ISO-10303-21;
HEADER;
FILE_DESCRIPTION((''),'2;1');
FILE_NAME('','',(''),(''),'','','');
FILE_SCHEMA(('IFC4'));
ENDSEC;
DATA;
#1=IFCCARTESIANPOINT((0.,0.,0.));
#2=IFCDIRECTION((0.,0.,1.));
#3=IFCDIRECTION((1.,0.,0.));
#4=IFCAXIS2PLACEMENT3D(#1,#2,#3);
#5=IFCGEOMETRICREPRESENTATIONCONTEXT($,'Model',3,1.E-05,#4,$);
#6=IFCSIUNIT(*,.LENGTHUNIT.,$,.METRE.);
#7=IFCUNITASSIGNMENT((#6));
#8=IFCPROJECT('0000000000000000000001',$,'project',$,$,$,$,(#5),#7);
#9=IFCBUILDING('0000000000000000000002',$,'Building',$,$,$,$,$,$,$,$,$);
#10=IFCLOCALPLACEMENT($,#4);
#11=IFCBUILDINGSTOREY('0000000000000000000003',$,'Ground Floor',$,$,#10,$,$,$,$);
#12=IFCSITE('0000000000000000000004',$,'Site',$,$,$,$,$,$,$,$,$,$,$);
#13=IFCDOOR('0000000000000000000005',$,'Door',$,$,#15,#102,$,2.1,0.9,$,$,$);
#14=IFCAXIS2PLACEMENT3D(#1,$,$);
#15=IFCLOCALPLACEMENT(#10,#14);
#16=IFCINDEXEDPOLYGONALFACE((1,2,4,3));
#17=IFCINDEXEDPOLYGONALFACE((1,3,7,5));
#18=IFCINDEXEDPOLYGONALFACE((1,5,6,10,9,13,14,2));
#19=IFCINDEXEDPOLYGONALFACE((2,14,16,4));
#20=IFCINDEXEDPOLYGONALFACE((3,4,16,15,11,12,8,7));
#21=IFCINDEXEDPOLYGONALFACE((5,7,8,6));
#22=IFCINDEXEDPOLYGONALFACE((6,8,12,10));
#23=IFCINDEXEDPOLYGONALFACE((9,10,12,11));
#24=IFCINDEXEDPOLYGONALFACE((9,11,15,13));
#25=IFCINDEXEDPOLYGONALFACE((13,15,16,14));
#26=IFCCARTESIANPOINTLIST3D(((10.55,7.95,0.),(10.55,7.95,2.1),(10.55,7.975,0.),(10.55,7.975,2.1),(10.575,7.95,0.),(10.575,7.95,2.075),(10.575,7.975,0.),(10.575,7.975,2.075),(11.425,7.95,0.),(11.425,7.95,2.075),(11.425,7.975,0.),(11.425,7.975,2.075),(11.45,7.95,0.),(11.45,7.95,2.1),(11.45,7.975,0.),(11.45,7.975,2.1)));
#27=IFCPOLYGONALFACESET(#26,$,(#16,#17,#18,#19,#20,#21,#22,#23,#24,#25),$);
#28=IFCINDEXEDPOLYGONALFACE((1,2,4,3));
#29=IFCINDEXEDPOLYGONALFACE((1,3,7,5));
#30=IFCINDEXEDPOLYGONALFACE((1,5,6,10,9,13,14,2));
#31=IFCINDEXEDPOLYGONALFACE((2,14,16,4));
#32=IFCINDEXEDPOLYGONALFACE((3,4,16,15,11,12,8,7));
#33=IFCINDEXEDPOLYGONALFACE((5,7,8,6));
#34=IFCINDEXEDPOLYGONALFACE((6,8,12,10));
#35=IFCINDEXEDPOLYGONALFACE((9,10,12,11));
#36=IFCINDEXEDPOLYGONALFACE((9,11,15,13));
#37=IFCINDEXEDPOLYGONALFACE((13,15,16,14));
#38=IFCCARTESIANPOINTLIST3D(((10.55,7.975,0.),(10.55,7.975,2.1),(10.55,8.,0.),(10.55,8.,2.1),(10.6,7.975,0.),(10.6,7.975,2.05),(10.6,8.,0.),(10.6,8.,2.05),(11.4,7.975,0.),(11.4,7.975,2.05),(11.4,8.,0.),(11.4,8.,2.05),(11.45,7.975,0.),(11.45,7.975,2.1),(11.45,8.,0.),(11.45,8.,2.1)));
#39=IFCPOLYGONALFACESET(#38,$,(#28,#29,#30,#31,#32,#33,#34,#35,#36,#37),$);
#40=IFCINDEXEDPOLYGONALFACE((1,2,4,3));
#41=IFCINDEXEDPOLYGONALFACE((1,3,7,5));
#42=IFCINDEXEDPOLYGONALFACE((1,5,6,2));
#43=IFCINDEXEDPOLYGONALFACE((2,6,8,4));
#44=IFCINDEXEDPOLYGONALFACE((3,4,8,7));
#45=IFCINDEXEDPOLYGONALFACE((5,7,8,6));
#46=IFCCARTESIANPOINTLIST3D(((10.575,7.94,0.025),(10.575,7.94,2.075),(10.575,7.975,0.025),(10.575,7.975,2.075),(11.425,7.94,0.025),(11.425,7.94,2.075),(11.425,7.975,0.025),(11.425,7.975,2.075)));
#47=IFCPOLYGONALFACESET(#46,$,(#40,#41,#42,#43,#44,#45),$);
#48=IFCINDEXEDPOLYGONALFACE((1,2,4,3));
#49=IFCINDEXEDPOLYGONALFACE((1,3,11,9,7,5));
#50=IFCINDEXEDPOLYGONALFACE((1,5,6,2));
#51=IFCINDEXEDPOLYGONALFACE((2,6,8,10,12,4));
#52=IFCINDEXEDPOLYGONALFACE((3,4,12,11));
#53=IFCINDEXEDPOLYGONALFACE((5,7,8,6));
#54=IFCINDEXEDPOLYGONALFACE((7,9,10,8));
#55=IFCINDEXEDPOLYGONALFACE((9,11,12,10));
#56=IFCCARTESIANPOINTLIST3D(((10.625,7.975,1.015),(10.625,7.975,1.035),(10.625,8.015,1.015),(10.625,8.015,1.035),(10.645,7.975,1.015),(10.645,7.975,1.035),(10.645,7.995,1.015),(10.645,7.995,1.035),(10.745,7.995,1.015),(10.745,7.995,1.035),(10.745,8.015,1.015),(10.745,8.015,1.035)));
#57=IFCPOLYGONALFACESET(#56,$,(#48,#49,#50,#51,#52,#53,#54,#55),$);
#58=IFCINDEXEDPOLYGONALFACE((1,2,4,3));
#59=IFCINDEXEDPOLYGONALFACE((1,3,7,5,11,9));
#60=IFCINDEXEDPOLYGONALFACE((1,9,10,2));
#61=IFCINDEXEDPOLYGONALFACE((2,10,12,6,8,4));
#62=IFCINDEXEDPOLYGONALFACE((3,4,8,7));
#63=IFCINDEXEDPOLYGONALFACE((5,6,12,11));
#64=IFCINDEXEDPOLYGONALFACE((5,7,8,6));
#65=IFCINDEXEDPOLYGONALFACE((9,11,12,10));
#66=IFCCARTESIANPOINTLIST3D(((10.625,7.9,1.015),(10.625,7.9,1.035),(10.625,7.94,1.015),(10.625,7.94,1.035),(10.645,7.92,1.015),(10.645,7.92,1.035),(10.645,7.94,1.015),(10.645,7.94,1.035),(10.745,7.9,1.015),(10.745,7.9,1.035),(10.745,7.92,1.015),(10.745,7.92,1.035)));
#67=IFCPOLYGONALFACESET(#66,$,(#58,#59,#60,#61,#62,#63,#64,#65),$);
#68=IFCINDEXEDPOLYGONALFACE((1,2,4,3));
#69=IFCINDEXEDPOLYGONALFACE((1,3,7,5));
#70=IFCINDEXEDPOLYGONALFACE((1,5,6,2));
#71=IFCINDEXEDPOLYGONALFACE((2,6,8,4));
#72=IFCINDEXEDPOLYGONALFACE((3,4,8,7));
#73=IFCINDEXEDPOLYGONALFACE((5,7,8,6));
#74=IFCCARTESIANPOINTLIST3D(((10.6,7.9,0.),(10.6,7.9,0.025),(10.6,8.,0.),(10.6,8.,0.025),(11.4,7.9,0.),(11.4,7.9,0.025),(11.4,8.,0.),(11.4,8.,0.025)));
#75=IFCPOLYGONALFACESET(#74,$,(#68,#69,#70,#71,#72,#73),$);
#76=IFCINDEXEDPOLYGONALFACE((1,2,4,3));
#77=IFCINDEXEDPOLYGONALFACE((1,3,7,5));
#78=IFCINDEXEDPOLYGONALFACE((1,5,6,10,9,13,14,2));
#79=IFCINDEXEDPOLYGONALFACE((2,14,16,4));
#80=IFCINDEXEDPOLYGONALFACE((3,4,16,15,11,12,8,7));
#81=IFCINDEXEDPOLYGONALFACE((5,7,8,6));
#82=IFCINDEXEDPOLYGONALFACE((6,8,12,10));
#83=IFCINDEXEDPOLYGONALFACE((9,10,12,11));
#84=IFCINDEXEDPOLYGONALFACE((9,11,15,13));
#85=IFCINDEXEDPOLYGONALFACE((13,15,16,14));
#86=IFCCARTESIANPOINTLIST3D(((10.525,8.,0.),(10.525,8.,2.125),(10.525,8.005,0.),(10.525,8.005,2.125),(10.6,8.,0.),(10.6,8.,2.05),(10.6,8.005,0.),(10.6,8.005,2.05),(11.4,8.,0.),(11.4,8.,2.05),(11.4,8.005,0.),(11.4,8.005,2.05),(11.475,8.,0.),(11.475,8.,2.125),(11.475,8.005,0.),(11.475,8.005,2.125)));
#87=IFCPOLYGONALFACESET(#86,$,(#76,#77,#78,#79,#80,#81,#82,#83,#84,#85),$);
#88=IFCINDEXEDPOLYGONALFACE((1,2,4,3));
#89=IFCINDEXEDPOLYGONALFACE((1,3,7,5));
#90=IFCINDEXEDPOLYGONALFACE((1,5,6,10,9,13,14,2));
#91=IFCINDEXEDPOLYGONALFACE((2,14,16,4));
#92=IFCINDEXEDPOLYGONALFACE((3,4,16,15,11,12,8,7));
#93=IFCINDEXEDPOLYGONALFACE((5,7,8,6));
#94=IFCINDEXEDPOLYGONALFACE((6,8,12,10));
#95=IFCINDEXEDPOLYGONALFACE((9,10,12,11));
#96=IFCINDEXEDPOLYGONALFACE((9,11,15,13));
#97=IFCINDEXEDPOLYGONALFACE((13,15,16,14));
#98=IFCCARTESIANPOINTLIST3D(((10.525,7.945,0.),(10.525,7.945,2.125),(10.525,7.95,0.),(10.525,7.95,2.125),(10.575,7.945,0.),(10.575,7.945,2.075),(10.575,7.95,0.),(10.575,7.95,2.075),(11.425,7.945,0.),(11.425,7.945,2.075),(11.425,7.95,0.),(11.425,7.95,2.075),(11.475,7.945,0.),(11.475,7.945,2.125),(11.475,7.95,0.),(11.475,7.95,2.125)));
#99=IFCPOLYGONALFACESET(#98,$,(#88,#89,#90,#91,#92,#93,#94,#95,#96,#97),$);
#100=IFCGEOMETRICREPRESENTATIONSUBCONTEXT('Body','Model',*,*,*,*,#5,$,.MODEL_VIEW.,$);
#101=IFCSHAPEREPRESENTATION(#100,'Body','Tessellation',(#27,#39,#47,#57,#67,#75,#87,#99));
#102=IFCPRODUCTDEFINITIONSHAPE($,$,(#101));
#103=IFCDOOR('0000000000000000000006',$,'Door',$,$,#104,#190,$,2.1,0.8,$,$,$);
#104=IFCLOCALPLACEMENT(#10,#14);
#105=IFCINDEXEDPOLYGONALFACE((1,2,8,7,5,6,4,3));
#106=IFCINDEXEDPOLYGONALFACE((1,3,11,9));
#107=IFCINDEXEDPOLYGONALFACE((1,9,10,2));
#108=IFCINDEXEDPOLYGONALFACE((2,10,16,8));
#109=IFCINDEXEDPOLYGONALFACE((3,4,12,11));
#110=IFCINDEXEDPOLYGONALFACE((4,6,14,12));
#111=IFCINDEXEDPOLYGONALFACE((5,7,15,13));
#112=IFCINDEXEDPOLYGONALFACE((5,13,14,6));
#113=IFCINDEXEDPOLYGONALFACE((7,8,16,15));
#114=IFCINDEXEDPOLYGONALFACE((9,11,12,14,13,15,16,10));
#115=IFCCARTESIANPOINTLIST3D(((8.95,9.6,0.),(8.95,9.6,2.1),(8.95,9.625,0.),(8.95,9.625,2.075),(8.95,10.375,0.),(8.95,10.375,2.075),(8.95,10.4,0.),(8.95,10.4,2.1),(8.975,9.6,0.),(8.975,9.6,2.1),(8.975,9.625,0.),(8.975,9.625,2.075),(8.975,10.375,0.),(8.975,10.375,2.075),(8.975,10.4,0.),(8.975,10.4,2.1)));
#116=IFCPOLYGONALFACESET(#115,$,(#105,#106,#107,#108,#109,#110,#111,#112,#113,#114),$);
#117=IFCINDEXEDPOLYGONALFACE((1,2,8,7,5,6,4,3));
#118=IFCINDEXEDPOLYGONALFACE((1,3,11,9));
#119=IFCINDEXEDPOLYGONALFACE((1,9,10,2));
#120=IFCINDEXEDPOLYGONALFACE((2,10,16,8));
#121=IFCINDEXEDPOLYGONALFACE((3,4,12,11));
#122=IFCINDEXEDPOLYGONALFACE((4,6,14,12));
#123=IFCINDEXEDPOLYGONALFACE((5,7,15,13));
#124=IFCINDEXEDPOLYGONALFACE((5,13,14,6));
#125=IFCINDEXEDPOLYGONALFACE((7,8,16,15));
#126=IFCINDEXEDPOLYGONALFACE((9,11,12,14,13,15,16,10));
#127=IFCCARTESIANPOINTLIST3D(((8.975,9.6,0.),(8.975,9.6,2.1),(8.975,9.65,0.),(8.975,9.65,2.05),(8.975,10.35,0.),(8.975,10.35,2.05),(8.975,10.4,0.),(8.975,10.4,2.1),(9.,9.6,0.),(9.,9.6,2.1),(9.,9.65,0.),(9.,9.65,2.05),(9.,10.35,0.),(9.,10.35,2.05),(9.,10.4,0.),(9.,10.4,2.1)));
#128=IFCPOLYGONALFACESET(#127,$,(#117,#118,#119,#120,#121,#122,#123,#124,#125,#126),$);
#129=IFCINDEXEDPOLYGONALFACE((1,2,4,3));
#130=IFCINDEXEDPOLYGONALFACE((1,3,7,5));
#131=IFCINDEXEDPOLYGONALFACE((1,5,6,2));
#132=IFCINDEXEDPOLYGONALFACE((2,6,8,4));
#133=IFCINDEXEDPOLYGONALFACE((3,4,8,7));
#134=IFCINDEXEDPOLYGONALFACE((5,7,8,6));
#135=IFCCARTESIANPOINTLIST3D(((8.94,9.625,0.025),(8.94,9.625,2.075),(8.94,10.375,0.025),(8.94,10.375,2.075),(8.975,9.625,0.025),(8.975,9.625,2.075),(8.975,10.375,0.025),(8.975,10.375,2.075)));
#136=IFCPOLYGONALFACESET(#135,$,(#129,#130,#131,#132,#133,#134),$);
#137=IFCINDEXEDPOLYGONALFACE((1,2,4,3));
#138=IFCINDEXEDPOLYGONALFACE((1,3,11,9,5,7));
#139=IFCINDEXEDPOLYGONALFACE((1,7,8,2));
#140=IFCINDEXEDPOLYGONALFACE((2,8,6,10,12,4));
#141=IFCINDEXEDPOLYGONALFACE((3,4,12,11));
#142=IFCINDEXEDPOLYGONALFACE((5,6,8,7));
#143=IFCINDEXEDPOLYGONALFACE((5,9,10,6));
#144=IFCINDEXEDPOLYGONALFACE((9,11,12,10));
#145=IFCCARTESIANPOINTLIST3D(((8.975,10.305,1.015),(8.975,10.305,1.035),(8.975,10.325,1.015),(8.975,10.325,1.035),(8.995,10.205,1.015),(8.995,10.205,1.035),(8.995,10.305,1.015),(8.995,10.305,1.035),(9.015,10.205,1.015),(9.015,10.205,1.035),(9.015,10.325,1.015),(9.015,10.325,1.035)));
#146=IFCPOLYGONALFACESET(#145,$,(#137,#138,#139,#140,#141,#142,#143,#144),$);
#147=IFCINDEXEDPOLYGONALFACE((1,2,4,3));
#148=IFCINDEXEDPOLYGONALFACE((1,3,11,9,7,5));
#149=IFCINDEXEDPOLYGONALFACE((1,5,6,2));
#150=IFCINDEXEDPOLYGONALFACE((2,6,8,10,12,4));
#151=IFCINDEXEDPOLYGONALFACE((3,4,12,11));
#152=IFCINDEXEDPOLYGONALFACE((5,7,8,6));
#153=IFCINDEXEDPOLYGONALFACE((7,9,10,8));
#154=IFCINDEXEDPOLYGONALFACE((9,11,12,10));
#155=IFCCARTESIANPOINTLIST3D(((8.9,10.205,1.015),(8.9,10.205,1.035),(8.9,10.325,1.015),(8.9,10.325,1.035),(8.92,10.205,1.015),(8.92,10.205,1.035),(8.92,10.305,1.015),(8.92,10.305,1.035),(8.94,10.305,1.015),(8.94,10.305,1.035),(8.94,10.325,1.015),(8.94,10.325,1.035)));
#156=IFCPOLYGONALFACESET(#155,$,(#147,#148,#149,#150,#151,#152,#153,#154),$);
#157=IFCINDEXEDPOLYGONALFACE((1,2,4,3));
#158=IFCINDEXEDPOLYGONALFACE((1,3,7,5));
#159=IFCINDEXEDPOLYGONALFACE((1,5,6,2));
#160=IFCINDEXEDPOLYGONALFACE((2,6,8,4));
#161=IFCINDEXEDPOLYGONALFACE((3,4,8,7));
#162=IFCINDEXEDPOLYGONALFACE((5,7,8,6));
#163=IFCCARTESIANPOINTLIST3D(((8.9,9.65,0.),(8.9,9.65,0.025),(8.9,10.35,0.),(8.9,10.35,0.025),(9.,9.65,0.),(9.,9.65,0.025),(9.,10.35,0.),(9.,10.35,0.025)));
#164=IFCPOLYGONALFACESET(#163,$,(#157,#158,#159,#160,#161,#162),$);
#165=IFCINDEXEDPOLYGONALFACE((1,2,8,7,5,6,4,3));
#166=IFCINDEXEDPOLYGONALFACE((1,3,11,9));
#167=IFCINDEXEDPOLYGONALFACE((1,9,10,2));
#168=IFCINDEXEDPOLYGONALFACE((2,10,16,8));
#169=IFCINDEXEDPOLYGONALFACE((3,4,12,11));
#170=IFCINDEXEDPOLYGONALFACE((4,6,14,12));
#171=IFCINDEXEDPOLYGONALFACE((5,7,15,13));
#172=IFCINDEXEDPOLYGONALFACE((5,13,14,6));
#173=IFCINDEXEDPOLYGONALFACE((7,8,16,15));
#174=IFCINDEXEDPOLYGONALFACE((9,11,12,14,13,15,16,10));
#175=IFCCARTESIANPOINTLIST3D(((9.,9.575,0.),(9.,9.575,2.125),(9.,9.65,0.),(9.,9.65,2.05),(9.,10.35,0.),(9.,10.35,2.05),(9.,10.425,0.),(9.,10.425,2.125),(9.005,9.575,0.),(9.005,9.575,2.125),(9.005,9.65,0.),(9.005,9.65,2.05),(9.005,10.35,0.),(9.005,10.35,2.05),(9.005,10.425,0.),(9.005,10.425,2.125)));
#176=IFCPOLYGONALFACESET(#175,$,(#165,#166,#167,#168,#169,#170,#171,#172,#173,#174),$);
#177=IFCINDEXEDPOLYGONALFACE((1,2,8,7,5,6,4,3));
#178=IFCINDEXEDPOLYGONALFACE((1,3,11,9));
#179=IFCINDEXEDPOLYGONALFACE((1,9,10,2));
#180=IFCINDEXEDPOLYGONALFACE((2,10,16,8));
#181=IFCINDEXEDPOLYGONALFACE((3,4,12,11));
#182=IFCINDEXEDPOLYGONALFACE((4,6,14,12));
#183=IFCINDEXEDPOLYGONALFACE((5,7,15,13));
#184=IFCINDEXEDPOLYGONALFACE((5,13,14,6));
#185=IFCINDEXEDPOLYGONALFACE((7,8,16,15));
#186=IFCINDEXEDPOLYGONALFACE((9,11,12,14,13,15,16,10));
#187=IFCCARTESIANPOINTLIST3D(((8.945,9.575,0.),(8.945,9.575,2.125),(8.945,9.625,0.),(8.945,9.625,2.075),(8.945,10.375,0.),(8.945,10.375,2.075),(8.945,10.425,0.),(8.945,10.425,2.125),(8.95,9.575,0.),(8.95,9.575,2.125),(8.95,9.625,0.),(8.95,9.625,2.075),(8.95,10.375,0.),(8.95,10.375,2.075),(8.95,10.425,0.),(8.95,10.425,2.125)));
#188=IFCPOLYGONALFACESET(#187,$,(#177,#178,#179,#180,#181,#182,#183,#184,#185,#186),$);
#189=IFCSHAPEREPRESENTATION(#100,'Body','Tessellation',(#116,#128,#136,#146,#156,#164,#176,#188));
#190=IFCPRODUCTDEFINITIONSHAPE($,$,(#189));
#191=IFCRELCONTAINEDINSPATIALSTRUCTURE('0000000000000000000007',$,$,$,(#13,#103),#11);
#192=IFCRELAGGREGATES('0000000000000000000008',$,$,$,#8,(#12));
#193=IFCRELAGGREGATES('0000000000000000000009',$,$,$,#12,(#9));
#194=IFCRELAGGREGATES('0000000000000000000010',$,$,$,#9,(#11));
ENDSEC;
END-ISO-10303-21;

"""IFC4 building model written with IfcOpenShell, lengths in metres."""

from ifc_helpers import new_model, si_unit, frame, origin_with_axes, place, context, subcontext, project, spatial, line, indexed_curve, outline, extrude, element, save


model = new_model("IFC4")

# Units and contexts
model_context = context("Model", 3, precision=1e-05, world=origin_with_axes())
body_context = subcontext(model_context, "Body", "Model", "MODEL_VIEW")
ifc_project = project(units=[si_unit("LENGTHUNIT", "METRE")], contexts=[model_context])

# Site, building, storey
site = spatial("IfcSite", under=ifc_project, Name="Site")
building = spatial("IfcBuilding", under=site, Name="Building")
storey_placement = place(None, origin_with_axes())
storey = spatial("IfcBuildingStorey", under=building, at=storey_placement, Name="Ground Floor")

# Doors
door_1_placement = place(storey_placement, frame((11.45, 8.0, 0.0), z_axis=(0.0, 0.0, 1.0), x_axis=(-1.0, 0.0, 0.0)))
element("IfcDoor", 1, at=door_1_placement, inside=storey, Name="Door", OverallHeight=2.1, OverallWidth=0.9, context=body_context, shape_type="SweptSolid", body=[
    extrude(outline(indexed_curve([(0.0, 0.0), (0.0, 2.1), (0.9, 2.1), (0.9, 0.0), (0.875, 0.0), (0.875, 2.075), (0.025, 2.075), (0.025, 0.0)], segments=[line(1, 2, 3, 4, 5, 6, 7, 8, 1)])), frame((0.0, 0.025, 0.0), z_axis=(0.0, -1.0, 0.0), x_axis=(1.0, 0.0, 0.0)), (0.0, 0.0, -1.0), 0.025),
    extrude(outline(indexed_curve([(0.0, 0.0), (0.0, 2.1), (0.9, 2.1), (0.9, 0.0), (0.85, 0.0), (0.85, 2.05), (0.05, 2.05), (0.05, 0.0)], segments=[line(1, 2, 3, 4, 5, 6, 7, 8, 1)])), frame((0.0, 0.0, 0.0), z_axis=(0.0, -1.0, 0.0), x_axis=(1.0, 0.0, 0.0)), (0.0, 0.0, -1.0), 0.025),
    extrude(outline(indexed_curve([(0.0, 0.0), (0.85, 0.0), (0.85, 0.035), (0.0, 0.035)], segments=[line(1, 2, 3, 4, 1)])), frame((0.025, 0.025, 0.025), z_axis=(0.0, 0.0, 1.0), x_axis=(1.0, 0.0, 0.0)), (0.0, 0.0, 1.0), 2.05),
    extrude(outline(indexed_curve([(0.0, 0.0), (0.0, -0.04), (-0.12, -0.04), (-0.12, -0.02), (-0.02, -0.02), (-0.02, 0.0)], segments=[line(1, 2, 3, 4, 5, 6, 1)])), frame((0.825, 0.025, 1.015), z_axis=(0.0, 0.0, 1.0), x_axis=(1.0, 0.0, 0.0)), (0.0, 0.0, 1.0), 0.02),
    extrude(outline(indexed_curve([(0.0, 0.0), (0.0, 0.04), (-0.12, 0.04), (-0.12, 0.02), (-0.02, 0.02), (-0.02, 0.0)], segments=[line(1, 2, 3, 4, 5, 6, 1)])), frame((0.825, 0.06, 1.015), z_axis=(0.0, 0.0, 1.0), x_axis=(1.0, 0.0, 0.0)), (0.0, 0.0, 1.0), 0.02),
    extrude(outline(indexed_curve([(0.0, 0.0), (0.8, 0.0), (0.8, 0.1), (0.0, 0.1)], segments=[line(1, 2, 3, 4, 1)])), frame((0.05, 0.0, 0.0), z_axis=(0.0, 0.0, 1.0), x_axis=(1.0, 0.0, 0.0)), (0.0, 0.0, 1.0), 0.025),
    extrude(outline(indexed_curve([(0.0, 0.0), (0.0, 2.125), (0.95, 2.125), (0.95, 0.0), (0.875, 0.0), (0.875, 2.05), (0.075, 2.05), (0.075, 0.0)], segments=[line(1, 2, 3, 4, 5, 6, 7, 8, 1)])), frame((-0.025, -0.005, 0.0), z_axis=(0.0, -1.0, 0.0), x_axis=(1.0, 0.0, 0.0)), (0.0, 0.0, -1.0), 0.005),
    extrude(outline(indexed_curve([(0.0, 0.0), (0.0, 2.125), (0.95, 2.125), (0.95, 0.0), (0.9, 0.0), (0.9, 2.075), (0.05, 2.075), (0.05, 0.0)], segments=[line(1, 2, 3, 4, 5, 6, 7, 8, 1)])), frame((-0.025, 0.05, 0.0), z_axis=(0.0, -1.0, 0.0), x_axis=(1.0, 0.0, 0.0)), (0.0, 0.0, -1.0), 0.005),
])
door_2_placement = place(storey_placement, frame((9.0, 9.6, 0.0), z_axis=(0.0, 0.0, 1.0), x_axis=(0.0, 1.0, 0.0)))
element("IfcDoor", 2, at=door_2_placement, inside=storey, Name="Door", OverallHeight=2.1, OverallWidth=0.8, context=body_context, shape_type="SweptSolid", body=[
    extrude(outline(indexed_curve([(0.0, 0.0), (0.0, 2.1), (0.8, 2.1), (0.8, 0.0), (0.775, 0.0), (0.775, 2.075), (0.025, 2.075), (0.025, 0.0)], segments=[line(1, 2, 3, 4, 5, 6, 7, 8, 1)])), frame((0.0, 0.025, 0.0), z_axis=(0.0, -1.0, 0.0), x_axis=(1.0, 0.0, 0.0)), (0.0, 0.0, -1.0), 0.025),
    extrude(outline(indexed_curve([(0.0, 0.0), (0.0, 2.1), (0.8, 2.1), (0.8, 0.0), (0.75, 0.0), (0.75, 2.05), (0.05, 2.05), (0.05, 0.0)], segments=[line(1, 2, 3, 4, 5, 6, 7, 8, 1)])), frame((0.0, 0.0, 0.0), z_axis=(0.0, -1.0, 0.0), x_axis=(1.0, 0.0, 0.0)), (0.0, 0.0, -1.0), 0.025),
    extrude(outline(indexed_curve([(0.0, 0.0), (0.75, 0.0), (0.75, 0.035), (0.0, 0.035)], segments=[line(1, 2, 3, 4, 1)])), frame((0.025, 0.025, 0.025), z_axis=(0.0, 0.0, 1.0), x_axis=(1.0, 0.0, 0.0)), (0.0, 0.0, 1.0), 2.05),
    extrude(outline(indexed_curve([(0.0, 0.0), (0.0, -0.04), (-0.12, -0.04), (-0.12, -0.02), (-0.02, -0.02), (-0.02, 0.0)], segments=[line(1, 2, 3, 4, 5, 6, 1)])), frame((0.725, 0.025, 1.015), z_axis=(0.0, 0.0, 1.0), x_axis=(1.0, 0.0, 0.0)), (0.0, 0.0, 1.0), 0.02),
    extrude(outline(indexed_curve([(0.0, 0.0), (0.0, 0.04), (-0.12, 0.04), (-0.12, 0.02), (-0.02, 0.02), (-0.02, 0.0)], segments=[line(1, 2, 3, 4, 5, 6, 1)])), frame((0.725, 0.06, 1.015), z_axis=(0.0, 0.0, 1.0), x_axis=(1.0, 0.0, 0.0)), (0.0, 0.0, 1.0), 0.02),
    extrude(outline(indexed_curve([(0.0, 0.0), (0.7, 0.0), (0.7, 0.1), (0.0, 0.1)], segments=[line(1, 2, 3, 4, 1)])), frame((0.05, 0.0, 0.0), z_axis=(0.0, 0.0, 1.0), x_axis=(1.0, 0.0, 0.0)), (0.0, 0.0, 1.0), 0.025),
    extrude(outline(indexed_curve([(0.0, 0.0), (0.0, 2.125), (0.85, 2.125), (0.85, 0.0), (0.775, 0.0), (0.775, 2.05), (0.075, 2.05), (0.075, 0.0)], segments=[line(1, 2, 3, 4, 5, 6, 7, 8, 1)])), frame((-0.025, -0.005, 0.0), z_axis=(0.0, -1.0, 0.0), x_axis=(1.0, 0.0, 0.0)), (0.0, 0.0, -1.0), 0.005),
    extrude(outline(indexed_curve([(0.0, 0.0), (0.0, 2.125), (0.85, 2.125), (0.85, 0.0), (0.8, 0.0), (0.8, 2.075), (0.05, 2.075), (0.05, 0.0)], segments=[line(1, 2, 3, 4, 5, 6, 7, 8, 1)])), frame((-0.025, 0.05, 0.0), z_axis=(0.0, -1.0, 0.0), x_axis=(1.0, 0.0, 0.0)), (0.0, 0.0, -1.0), 0.005),
])

save(model, "model.ifc")
